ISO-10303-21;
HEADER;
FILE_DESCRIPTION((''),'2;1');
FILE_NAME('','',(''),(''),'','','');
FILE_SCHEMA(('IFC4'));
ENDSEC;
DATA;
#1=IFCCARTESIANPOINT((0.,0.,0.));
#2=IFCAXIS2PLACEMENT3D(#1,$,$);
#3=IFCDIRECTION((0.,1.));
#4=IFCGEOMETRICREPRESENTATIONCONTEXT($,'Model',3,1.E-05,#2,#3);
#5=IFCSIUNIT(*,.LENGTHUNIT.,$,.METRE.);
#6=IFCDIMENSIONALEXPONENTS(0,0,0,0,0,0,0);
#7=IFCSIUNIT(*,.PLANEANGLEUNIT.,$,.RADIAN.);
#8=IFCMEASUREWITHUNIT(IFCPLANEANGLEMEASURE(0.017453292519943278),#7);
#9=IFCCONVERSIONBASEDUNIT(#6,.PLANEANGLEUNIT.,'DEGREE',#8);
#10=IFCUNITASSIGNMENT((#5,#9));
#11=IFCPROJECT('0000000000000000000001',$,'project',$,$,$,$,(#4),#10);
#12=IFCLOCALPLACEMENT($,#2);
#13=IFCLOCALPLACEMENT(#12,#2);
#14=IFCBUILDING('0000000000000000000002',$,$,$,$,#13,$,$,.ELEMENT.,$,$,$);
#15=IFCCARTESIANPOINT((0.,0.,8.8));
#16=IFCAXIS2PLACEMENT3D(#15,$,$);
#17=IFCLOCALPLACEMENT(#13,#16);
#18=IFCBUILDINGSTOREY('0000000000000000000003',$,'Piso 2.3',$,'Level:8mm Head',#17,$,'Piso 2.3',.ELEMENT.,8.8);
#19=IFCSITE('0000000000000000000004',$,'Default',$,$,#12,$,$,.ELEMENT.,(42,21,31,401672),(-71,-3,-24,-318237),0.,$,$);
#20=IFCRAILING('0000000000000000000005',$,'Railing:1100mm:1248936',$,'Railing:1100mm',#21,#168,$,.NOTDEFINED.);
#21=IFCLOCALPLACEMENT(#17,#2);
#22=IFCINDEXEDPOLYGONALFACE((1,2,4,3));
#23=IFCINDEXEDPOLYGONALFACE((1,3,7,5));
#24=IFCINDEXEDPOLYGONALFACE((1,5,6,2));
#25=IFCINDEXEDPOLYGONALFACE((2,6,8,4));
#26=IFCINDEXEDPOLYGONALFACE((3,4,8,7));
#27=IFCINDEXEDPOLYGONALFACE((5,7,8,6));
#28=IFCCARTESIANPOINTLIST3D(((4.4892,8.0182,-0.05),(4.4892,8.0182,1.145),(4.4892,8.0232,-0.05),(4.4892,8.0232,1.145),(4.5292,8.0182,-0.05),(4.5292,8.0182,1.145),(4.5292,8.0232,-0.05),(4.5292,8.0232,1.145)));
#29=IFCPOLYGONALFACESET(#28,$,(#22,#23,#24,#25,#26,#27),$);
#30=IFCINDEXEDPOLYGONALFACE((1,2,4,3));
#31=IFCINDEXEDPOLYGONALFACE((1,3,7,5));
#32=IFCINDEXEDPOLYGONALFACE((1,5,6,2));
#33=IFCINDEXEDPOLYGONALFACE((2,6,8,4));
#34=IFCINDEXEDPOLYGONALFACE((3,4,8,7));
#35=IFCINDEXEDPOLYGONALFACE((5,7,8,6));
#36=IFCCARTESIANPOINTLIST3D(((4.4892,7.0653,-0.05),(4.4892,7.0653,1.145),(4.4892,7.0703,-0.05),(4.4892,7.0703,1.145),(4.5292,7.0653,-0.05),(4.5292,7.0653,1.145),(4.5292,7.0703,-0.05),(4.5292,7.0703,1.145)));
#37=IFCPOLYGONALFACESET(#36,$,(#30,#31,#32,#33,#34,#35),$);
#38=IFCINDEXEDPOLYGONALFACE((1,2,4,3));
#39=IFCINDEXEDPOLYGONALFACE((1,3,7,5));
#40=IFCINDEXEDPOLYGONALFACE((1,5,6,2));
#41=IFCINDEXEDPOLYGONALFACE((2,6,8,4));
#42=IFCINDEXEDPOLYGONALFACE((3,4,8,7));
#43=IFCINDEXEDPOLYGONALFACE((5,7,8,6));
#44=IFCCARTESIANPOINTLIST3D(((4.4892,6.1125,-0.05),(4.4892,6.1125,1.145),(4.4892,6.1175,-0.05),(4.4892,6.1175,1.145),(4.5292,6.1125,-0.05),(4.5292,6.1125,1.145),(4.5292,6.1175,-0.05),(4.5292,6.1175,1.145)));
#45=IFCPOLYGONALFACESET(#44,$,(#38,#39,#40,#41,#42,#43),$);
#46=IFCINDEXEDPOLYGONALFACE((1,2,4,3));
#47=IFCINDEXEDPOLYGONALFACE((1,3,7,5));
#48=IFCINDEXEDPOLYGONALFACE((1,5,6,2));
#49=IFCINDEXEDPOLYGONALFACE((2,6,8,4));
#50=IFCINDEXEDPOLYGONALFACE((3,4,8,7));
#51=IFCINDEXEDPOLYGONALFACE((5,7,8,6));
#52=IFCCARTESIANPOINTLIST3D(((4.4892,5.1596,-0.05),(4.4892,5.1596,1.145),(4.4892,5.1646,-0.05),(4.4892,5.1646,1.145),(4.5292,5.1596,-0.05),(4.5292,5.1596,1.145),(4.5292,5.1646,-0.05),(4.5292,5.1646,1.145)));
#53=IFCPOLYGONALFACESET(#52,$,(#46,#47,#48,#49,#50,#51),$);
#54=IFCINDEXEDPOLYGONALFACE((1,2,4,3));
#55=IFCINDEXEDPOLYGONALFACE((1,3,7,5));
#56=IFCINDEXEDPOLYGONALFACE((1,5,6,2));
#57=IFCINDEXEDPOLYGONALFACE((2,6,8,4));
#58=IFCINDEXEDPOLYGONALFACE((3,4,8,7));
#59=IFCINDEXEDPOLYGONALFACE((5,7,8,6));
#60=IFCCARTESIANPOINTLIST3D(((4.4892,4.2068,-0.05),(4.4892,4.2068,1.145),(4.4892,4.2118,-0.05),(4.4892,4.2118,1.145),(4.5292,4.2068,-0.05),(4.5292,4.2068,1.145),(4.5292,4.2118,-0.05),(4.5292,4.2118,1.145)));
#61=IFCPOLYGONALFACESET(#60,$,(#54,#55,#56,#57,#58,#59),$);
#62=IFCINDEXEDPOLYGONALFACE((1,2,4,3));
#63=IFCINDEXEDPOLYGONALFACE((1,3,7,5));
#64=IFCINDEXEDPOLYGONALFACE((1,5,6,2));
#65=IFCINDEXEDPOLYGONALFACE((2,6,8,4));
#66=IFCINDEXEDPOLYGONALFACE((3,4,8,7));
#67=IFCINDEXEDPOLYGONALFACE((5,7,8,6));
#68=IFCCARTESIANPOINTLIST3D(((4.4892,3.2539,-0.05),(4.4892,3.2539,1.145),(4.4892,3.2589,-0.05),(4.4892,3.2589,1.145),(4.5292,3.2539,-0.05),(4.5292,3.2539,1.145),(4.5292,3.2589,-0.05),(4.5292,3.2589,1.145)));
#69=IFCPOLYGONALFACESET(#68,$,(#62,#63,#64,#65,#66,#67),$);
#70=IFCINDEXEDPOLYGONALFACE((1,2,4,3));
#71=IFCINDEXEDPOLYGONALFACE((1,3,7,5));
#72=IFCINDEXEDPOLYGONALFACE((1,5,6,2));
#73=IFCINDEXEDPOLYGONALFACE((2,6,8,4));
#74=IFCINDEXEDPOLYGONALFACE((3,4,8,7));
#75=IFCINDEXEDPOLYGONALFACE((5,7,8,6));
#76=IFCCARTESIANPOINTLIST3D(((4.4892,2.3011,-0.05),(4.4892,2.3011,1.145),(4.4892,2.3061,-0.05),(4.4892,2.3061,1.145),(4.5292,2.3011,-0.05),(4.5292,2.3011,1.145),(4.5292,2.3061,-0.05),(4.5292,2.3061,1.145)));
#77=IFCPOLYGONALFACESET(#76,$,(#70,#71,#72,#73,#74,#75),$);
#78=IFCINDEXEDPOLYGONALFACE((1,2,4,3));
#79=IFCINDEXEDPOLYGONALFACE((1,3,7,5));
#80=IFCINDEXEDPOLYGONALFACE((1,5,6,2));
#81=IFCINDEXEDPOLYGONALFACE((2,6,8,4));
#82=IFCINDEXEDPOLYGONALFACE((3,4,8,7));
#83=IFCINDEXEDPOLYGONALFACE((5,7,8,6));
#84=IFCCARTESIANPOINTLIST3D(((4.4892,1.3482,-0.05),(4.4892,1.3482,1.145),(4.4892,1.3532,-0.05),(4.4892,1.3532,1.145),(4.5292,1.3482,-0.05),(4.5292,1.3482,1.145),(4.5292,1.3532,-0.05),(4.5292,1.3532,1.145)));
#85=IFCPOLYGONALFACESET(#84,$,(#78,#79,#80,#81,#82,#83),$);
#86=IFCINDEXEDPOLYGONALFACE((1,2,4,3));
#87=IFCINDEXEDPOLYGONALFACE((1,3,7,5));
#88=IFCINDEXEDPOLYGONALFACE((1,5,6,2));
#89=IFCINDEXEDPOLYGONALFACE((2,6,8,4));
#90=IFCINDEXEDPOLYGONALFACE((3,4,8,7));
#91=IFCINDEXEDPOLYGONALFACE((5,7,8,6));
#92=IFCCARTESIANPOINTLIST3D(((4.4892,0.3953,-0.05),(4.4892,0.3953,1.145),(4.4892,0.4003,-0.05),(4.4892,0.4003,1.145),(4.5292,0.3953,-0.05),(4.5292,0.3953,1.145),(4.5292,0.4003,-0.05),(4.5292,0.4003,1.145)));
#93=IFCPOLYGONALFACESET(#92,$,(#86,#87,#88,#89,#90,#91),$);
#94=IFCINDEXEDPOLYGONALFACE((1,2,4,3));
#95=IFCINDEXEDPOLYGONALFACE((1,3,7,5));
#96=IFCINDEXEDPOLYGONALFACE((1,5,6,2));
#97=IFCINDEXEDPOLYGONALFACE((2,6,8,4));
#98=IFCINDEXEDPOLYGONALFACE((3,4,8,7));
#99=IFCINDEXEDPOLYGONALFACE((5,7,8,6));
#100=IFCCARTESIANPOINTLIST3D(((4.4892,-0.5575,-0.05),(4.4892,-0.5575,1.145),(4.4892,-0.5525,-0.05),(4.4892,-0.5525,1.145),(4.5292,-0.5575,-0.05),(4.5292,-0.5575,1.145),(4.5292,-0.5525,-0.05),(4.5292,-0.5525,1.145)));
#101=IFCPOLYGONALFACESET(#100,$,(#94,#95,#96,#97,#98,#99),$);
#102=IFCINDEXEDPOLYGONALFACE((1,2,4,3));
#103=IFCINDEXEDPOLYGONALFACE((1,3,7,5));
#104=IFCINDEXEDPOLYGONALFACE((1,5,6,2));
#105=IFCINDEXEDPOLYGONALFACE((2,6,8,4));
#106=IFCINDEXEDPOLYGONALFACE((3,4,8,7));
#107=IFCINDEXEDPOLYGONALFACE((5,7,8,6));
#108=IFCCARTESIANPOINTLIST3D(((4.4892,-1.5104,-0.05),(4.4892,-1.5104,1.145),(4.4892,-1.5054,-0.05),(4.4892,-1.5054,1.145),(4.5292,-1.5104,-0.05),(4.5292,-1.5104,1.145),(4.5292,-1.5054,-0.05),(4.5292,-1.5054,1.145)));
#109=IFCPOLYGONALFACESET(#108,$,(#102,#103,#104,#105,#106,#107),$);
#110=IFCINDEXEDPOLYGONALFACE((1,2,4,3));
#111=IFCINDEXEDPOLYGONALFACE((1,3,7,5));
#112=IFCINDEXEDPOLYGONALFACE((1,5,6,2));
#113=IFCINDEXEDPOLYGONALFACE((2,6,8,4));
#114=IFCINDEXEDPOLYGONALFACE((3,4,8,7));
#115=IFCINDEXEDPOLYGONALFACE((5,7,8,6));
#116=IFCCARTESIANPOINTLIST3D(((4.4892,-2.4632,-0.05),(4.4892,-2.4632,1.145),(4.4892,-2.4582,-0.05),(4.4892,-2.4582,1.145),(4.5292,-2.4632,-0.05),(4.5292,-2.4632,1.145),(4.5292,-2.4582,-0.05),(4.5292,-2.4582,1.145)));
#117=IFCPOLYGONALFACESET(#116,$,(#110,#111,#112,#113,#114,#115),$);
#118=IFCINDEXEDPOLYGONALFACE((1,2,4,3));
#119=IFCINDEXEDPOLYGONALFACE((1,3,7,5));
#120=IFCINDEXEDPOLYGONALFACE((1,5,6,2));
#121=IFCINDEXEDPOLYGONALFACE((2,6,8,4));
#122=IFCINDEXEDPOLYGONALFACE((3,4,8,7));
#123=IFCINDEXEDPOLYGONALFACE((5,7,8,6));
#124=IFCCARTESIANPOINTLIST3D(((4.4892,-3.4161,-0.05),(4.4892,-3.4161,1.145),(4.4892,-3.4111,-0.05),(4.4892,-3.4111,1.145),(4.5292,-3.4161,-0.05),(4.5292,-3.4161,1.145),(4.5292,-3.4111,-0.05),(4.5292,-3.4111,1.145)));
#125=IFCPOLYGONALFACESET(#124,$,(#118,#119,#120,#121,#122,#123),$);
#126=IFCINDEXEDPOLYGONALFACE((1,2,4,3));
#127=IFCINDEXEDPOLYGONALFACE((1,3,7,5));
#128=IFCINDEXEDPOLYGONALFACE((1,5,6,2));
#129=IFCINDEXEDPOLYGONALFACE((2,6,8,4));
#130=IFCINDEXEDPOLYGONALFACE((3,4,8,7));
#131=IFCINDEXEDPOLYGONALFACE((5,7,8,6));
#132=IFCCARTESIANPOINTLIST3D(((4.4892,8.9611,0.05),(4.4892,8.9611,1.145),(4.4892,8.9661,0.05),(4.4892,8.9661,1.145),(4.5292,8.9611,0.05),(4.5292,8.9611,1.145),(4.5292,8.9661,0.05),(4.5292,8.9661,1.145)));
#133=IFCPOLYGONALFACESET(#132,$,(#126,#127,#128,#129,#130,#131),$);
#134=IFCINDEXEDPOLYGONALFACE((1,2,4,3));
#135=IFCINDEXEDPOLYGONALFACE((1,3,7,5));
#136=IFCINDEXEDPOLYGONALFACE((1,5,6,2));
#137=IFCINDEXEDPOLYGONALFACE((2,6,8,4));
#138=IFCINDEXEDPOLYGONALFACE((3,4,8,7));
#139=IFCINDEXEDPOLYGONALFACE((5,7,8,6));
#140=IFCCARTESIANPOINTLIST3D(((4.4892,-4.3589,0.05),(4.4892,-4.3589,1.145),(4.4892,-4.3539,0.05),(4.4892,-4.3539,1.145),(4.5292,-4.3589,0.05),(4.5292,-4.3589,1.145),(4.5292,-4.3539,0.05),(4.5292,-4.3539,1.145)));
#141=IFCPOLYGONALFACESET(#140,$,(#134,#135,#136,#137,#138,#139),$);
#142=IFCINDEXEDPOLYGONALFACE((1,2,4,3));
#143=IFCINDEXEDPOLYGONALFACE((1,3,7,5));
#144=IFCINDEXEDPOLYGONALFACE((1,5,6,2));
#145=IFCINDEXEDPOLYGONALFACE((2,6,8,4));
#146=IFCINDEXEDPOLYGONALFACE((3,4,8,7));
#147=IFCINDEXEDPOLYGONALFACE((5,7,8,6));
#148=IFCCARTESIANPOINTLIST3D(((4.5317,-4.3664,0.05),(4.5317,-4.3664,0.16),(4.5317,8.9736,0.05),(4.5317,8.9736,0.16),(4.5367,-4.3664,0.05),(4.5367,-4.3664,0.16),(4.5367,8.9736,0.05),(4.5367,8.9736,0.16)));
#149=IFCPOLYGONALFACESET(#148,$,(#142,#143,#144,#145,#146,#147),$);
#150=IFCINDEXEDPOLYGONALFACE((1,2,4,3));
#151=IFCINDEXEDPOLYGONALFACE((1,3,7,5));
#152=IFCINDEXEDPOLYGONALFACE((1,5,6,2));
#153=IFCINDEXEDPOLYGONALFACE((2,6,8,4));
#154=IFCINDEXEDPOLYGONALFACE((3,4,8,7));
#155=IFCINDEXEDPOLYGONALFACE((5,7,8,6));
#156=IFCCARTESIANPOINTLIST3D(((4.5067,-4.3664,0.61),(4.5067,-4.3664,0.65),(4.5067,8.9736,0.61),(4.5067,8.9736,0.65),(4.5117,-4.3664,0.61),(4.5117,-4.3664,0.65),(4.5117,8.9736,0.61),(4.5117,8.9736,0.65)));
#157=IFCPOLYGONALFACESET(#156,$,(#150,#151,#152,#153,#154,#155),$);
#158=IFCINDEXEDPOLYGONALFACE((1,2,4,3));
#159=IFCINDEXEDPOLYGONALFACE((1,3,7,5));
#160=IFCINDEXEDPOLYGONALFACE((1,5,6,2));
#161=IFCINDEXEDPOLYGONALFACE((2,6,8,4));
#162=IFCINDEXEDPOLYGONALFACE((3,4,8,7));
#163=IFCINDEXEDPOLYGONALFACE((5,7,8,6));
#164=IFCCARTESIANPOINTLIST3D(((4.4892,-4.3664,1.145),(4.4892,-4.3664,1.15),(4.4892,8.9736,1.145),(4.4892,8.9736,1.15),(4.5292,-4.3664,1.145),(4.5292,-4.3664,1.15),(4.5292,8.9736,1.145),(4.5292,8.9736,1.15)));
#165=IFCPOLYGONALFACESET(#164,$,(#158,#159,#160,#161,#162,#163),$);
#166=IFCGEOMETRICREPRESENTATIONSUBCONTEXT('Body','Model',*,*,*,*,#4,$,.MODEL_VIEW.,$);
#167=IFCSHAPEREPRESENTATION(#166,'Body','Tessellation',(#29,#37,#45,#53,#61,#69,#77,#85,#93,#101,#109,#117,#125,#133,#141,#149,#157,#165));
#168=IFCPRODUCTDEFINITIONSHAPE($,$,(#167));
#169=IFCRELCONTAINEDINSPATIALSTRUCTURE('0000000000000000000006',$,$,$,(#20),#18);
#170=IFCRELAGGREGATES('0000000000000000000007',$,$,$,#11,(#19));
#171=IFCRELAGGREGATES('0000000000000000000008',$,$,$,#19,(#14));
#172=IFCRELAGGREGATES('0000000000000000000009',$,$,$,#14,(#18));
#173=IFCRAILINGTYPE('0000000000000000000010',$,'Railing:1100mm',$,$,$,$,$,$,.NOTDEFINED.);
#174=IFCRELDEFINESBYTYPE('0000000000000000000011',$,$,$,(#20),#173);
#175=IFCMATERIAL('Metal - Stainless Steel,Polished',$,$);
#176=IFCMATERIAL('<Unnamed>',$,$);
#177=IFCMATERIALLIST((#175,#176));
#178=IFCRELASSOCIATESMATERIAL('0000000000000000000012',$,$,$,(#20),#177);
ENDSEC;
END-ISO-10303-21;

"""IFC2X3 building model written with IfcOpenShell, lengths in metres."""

from ifc_helpers import new_model, entity, si_unit, converted_unit, direction, frame, frame_2d, origin, origin_2d_with_axis, place, context, subcontext, project, spatial, rectangle, extrude, material, material_list, type_object, element, save


model = new_model("IFC2X3")

# Units and contexts
model_context = context("Model", 3, precision=1e-05, world=origin(), true_north=direction((0.0, 1.0)))
body_context = subcontext(model_context, "Body", "Model", "MODEL_VIEW")
ifc_project = project(units=[si_unit("LENGTHUNIT", "METRE"), converted_unit("PLANEANGLEUNIT", "DEGREE", entity("IfcPlaneAngleMeasure", 0.017453292519943278), si_unit("PLANEANGLEUNIT", "RADIAN"), dimensions=[0, 0, 0, 0, 0, 0, 0])], contexts=[model_context])

# Site, building, storey
site_placement = place(None, origin())
site = spatial("IfcSite", under=ifc_project, at=site_placement, Name="Default", CompositionType="ELEMENT", RefLatitude=(42, 21, 31, 401672), RefLongitude=(-71, -3, -24, -318237), RefElevation=0.0)
building_placement = place(site_placement, origin())
building = spatial("IfcBuilding", under=site, at=building_placement, CompositionType="ELEMENT")
storey_placement = place(building_placement, frame((0.0, 0.0, 8.8)))
storey = spatial("IfcBuildingStorey", under=building, at=storey_placement, Name="Piso 2.3", ObjectType="Level:8mm Head", LongName="Piso 2.3", CompositionType="ELEMENT", Elevation=8.8)

# Railing
ifc_material_1 = material(Name="Metal - Stainless Steel,Polished")
ifc_material_2 = material(Name="<Unnamed>")
ifc_material_list = material_list([ifc_material_1, ifc_material_2])
railing_type = type_object("IfcRailingType", Name="Railing:1100mm", PredefinedType="NOTDEFINED")
railing_placement = place(storey_placement, frame((4.4892, -4.3664, -0.05)))
element("IfcRailing", 1, at=railing_placement, inside=storey, type_object=railing_type, material=ifc_material_list, Name="Railing:1100mm:1248936", ObjectType="Railing:1100mm", PredefinedType="NOTDEFINED", context=body_context, shape_type="SweptSolid", body=[
    extrude(rectangle(XDim=0.005, YDim=0.04, at=frame_2d((0.0, 0.0), x_axis=(1.0, 0.0))), frame((0.02, 12.3871, 0.0), z_axis=(0.0, 0.0, 1.0), x_axis=(0.0, 1.0, 0.0)), (0.0, 0.0, 1.0), 1.195),
    extrude(rectangle(XDim=0.005, YDim=0.04, at=frame_2d((0.0, 0.0), x_axis=(1.0, 0.0))), frame((0.02, 11.4343, 0.0), z_axis=(0.0, 0.0, 1.0), x_axis=(0.0, 1.0, 0.0)), (0.0, 0.0, 1.0), 1.195),
    extrude(rectangle(XDim=0.005, YDim=0.04, at=frame_2d((0.0, 0.0), x_axis=(1.0, 0.0))), frame((0.02, 10.4814, 0.0), z_axis=(0.0, 0.0, 1.0), x_axis=(0.0, 1.0, 0.0)), (0.0, 0.0, 1.0), 1.195),
    extrude(rectangle(XDim=0.005, YDim=0.04, at=frame_2d((0.0, 0.0), x_axis=(1.0, 0.0))), frame((0.02, 9.5286, 0.0), z_axis=(0.0, 0.0, 1.0), x_axis=(0.0, 1.0, 0.0)), (0.0, 0.0, 1.0), 1.195),
    extrude(rectangle(XDim=0.005, YDim=0.04, at=frame_2d((0.0, 0.0), x_axis=(1.0, 0.0))), frame((0.02, 8.5757, 0.0), z_axis=(0.0, 0.0, 1.0), x_axis=(0.0, 1.0, 0.0)), (0.0, 0.0, 1.0), 1.195),
    extrude(rectangle(XDim=0.005, YDim=0.04, at=frame_2d((0.0, 0.0), x_axis=(1.0, 0.0))), frame((0.02, 7.6229, 0.0), z_axis=(0.0, 0.0, 1.0), x_axis=(0.0, 1.0, 0.0)), (0.0, 0.0, 1.0), 1.195),
    extrude(rectangle(XDim=0.005, YDim=0.04, at=frame_2d((0.0, 0.0), x_axis=(1.0, 0.0))), frame((0.02, 6.67, 0.0), z_axis=(0.0, 0.0, 1.0), x_axis=(0.0, 1.0, 0.0)), (0.0, 0.0, 1.0), 1.195),
    extrude(rectangle(XDim=0.005, YDim=0.04, at=frame_2d((0.0, 0.0), x_axis=(1.0, 0.0))), frame((0.02, 5.7171, 0.0), z_axis=(0.0, 0.0, 1.0), x_axis=(0.0, 1.0, 0.0)), (0.0, 0.0, 1.0), 1.195),
    extrude(rectangle(XDim=0.005, YDim=0.04, at=frame_2d((0.0, 0.0), x_axis=(1.0, 0.0))), frame((0.02, 4.7643, 0.0), z_axis=(0.0, 0.0, 1.0), x_axis=(0.0, 1.0, 0.0)), (0.0, 0.0, 1.0), 1.195),
    extrude(rectangle(XDim=0.005, YDim=0.04, at=frame_2d((0.0, 0.0), x_axis=(1.0, 0.0))), frame((0.02, 3.8114, 0.0), z_axis=(0.0, 0.0, 1.0), x_axis=(0.0, 1.0, 0.0)), (0.0, 0.0, 1.0), 1.195),
    extrude(rectangle(XDim=0.005, YDim=0.04, at=frame_2d((0.0, 0.0), x_axis=(1.0, 0.0))), frame((0.02, 2.8586, 0.0), z_axis=(0.0, 0.0, 1.0), x_axis=(0.0, 1.0, 0.0)), (0.0, 0.0, 1.0), 1.195),
    extrude(rectangle(XDim=0.005, YDim=0.04, at=frame_2d((0.0, 0.0), x_axis=(1.0, 0.0))), frame((0.02, 1.9057, 0.0), z_axis=(0.0, 0.0, 1.0), x_axis=(0.0, 1.0, 0.0)), (0.0, 0.0, 1.0), 1.195),
    extrude(rectangle(XDim=0.005, YDim=0.04, at=frame_2d((0.0, 0.0), x_axis=(1.0, 0.0))), frame((0.02, 0.9529, 0.0), z_axis=(0.0, 0.0, 1.0), x_axis=(0.0, 1.0, 0.0)), (0.0, 0.0, 1.0), 1.195),
    extrude(rectangle(XDim=0.005, YDim=0.04, at=frame_2d((0.0, 0.0), x_axis=(1.0, 0.0))), frame((0.02, 13.33, 0.1), z_axis=(0.0, 0.0, 1.0), x_axis=(0.0, 1.0, 0.0)), (0.0, 0.0, 1.0), 1.095),
    extrude(rectangle(XDim=0.005, YDim=0.04, at=frame_2d((0.0, 0.0), x_axis=(1.0, 0.0))), frame((0.02, 0.01, 0.1), z_axis=(0.0, 0.0, 1.0), x_axis=(0.0, 1.0, 0.0)), (0.0, 0.0, 1.0), 1.095),
    extrude(rectangle(XDim=13.34, YDim=0.005, at=frame_2d((0.0, 0.0), x_axis=(1.0, 0.0))), frame((0.045, 6.67, 0.1), z_axis=(0.0, 0.0, 1.0), x_axis=(0.0, 1.0, 0.0)), (0.0, 0.0, 1.0), 0.11),
    extrude(rectangle(XDim=13.34, YDim=0.005, at=frame_2d((0.0, 0.0), x_axis=(1.0, 0.0))), frame((0.02, 6.67, 0.66), z_axis=(0.0, 0.0, 1.0), x_axis=(0.0, 1.0, 0.0)), (0.0, 0.0, 1.0), 0.04),
    extrude(rectangle(XDim=13.34, YDim=0.04, at=origin_2d_with_axis()), frame((0.02, 6.67, 1.195), z_axis=(0.0, 0.0, 1.0), x_axis=(0.0, 1.0, 0.0)), (0.0, 0.0, 1.0), 0.005),
])

save(model, "model.ifc")
